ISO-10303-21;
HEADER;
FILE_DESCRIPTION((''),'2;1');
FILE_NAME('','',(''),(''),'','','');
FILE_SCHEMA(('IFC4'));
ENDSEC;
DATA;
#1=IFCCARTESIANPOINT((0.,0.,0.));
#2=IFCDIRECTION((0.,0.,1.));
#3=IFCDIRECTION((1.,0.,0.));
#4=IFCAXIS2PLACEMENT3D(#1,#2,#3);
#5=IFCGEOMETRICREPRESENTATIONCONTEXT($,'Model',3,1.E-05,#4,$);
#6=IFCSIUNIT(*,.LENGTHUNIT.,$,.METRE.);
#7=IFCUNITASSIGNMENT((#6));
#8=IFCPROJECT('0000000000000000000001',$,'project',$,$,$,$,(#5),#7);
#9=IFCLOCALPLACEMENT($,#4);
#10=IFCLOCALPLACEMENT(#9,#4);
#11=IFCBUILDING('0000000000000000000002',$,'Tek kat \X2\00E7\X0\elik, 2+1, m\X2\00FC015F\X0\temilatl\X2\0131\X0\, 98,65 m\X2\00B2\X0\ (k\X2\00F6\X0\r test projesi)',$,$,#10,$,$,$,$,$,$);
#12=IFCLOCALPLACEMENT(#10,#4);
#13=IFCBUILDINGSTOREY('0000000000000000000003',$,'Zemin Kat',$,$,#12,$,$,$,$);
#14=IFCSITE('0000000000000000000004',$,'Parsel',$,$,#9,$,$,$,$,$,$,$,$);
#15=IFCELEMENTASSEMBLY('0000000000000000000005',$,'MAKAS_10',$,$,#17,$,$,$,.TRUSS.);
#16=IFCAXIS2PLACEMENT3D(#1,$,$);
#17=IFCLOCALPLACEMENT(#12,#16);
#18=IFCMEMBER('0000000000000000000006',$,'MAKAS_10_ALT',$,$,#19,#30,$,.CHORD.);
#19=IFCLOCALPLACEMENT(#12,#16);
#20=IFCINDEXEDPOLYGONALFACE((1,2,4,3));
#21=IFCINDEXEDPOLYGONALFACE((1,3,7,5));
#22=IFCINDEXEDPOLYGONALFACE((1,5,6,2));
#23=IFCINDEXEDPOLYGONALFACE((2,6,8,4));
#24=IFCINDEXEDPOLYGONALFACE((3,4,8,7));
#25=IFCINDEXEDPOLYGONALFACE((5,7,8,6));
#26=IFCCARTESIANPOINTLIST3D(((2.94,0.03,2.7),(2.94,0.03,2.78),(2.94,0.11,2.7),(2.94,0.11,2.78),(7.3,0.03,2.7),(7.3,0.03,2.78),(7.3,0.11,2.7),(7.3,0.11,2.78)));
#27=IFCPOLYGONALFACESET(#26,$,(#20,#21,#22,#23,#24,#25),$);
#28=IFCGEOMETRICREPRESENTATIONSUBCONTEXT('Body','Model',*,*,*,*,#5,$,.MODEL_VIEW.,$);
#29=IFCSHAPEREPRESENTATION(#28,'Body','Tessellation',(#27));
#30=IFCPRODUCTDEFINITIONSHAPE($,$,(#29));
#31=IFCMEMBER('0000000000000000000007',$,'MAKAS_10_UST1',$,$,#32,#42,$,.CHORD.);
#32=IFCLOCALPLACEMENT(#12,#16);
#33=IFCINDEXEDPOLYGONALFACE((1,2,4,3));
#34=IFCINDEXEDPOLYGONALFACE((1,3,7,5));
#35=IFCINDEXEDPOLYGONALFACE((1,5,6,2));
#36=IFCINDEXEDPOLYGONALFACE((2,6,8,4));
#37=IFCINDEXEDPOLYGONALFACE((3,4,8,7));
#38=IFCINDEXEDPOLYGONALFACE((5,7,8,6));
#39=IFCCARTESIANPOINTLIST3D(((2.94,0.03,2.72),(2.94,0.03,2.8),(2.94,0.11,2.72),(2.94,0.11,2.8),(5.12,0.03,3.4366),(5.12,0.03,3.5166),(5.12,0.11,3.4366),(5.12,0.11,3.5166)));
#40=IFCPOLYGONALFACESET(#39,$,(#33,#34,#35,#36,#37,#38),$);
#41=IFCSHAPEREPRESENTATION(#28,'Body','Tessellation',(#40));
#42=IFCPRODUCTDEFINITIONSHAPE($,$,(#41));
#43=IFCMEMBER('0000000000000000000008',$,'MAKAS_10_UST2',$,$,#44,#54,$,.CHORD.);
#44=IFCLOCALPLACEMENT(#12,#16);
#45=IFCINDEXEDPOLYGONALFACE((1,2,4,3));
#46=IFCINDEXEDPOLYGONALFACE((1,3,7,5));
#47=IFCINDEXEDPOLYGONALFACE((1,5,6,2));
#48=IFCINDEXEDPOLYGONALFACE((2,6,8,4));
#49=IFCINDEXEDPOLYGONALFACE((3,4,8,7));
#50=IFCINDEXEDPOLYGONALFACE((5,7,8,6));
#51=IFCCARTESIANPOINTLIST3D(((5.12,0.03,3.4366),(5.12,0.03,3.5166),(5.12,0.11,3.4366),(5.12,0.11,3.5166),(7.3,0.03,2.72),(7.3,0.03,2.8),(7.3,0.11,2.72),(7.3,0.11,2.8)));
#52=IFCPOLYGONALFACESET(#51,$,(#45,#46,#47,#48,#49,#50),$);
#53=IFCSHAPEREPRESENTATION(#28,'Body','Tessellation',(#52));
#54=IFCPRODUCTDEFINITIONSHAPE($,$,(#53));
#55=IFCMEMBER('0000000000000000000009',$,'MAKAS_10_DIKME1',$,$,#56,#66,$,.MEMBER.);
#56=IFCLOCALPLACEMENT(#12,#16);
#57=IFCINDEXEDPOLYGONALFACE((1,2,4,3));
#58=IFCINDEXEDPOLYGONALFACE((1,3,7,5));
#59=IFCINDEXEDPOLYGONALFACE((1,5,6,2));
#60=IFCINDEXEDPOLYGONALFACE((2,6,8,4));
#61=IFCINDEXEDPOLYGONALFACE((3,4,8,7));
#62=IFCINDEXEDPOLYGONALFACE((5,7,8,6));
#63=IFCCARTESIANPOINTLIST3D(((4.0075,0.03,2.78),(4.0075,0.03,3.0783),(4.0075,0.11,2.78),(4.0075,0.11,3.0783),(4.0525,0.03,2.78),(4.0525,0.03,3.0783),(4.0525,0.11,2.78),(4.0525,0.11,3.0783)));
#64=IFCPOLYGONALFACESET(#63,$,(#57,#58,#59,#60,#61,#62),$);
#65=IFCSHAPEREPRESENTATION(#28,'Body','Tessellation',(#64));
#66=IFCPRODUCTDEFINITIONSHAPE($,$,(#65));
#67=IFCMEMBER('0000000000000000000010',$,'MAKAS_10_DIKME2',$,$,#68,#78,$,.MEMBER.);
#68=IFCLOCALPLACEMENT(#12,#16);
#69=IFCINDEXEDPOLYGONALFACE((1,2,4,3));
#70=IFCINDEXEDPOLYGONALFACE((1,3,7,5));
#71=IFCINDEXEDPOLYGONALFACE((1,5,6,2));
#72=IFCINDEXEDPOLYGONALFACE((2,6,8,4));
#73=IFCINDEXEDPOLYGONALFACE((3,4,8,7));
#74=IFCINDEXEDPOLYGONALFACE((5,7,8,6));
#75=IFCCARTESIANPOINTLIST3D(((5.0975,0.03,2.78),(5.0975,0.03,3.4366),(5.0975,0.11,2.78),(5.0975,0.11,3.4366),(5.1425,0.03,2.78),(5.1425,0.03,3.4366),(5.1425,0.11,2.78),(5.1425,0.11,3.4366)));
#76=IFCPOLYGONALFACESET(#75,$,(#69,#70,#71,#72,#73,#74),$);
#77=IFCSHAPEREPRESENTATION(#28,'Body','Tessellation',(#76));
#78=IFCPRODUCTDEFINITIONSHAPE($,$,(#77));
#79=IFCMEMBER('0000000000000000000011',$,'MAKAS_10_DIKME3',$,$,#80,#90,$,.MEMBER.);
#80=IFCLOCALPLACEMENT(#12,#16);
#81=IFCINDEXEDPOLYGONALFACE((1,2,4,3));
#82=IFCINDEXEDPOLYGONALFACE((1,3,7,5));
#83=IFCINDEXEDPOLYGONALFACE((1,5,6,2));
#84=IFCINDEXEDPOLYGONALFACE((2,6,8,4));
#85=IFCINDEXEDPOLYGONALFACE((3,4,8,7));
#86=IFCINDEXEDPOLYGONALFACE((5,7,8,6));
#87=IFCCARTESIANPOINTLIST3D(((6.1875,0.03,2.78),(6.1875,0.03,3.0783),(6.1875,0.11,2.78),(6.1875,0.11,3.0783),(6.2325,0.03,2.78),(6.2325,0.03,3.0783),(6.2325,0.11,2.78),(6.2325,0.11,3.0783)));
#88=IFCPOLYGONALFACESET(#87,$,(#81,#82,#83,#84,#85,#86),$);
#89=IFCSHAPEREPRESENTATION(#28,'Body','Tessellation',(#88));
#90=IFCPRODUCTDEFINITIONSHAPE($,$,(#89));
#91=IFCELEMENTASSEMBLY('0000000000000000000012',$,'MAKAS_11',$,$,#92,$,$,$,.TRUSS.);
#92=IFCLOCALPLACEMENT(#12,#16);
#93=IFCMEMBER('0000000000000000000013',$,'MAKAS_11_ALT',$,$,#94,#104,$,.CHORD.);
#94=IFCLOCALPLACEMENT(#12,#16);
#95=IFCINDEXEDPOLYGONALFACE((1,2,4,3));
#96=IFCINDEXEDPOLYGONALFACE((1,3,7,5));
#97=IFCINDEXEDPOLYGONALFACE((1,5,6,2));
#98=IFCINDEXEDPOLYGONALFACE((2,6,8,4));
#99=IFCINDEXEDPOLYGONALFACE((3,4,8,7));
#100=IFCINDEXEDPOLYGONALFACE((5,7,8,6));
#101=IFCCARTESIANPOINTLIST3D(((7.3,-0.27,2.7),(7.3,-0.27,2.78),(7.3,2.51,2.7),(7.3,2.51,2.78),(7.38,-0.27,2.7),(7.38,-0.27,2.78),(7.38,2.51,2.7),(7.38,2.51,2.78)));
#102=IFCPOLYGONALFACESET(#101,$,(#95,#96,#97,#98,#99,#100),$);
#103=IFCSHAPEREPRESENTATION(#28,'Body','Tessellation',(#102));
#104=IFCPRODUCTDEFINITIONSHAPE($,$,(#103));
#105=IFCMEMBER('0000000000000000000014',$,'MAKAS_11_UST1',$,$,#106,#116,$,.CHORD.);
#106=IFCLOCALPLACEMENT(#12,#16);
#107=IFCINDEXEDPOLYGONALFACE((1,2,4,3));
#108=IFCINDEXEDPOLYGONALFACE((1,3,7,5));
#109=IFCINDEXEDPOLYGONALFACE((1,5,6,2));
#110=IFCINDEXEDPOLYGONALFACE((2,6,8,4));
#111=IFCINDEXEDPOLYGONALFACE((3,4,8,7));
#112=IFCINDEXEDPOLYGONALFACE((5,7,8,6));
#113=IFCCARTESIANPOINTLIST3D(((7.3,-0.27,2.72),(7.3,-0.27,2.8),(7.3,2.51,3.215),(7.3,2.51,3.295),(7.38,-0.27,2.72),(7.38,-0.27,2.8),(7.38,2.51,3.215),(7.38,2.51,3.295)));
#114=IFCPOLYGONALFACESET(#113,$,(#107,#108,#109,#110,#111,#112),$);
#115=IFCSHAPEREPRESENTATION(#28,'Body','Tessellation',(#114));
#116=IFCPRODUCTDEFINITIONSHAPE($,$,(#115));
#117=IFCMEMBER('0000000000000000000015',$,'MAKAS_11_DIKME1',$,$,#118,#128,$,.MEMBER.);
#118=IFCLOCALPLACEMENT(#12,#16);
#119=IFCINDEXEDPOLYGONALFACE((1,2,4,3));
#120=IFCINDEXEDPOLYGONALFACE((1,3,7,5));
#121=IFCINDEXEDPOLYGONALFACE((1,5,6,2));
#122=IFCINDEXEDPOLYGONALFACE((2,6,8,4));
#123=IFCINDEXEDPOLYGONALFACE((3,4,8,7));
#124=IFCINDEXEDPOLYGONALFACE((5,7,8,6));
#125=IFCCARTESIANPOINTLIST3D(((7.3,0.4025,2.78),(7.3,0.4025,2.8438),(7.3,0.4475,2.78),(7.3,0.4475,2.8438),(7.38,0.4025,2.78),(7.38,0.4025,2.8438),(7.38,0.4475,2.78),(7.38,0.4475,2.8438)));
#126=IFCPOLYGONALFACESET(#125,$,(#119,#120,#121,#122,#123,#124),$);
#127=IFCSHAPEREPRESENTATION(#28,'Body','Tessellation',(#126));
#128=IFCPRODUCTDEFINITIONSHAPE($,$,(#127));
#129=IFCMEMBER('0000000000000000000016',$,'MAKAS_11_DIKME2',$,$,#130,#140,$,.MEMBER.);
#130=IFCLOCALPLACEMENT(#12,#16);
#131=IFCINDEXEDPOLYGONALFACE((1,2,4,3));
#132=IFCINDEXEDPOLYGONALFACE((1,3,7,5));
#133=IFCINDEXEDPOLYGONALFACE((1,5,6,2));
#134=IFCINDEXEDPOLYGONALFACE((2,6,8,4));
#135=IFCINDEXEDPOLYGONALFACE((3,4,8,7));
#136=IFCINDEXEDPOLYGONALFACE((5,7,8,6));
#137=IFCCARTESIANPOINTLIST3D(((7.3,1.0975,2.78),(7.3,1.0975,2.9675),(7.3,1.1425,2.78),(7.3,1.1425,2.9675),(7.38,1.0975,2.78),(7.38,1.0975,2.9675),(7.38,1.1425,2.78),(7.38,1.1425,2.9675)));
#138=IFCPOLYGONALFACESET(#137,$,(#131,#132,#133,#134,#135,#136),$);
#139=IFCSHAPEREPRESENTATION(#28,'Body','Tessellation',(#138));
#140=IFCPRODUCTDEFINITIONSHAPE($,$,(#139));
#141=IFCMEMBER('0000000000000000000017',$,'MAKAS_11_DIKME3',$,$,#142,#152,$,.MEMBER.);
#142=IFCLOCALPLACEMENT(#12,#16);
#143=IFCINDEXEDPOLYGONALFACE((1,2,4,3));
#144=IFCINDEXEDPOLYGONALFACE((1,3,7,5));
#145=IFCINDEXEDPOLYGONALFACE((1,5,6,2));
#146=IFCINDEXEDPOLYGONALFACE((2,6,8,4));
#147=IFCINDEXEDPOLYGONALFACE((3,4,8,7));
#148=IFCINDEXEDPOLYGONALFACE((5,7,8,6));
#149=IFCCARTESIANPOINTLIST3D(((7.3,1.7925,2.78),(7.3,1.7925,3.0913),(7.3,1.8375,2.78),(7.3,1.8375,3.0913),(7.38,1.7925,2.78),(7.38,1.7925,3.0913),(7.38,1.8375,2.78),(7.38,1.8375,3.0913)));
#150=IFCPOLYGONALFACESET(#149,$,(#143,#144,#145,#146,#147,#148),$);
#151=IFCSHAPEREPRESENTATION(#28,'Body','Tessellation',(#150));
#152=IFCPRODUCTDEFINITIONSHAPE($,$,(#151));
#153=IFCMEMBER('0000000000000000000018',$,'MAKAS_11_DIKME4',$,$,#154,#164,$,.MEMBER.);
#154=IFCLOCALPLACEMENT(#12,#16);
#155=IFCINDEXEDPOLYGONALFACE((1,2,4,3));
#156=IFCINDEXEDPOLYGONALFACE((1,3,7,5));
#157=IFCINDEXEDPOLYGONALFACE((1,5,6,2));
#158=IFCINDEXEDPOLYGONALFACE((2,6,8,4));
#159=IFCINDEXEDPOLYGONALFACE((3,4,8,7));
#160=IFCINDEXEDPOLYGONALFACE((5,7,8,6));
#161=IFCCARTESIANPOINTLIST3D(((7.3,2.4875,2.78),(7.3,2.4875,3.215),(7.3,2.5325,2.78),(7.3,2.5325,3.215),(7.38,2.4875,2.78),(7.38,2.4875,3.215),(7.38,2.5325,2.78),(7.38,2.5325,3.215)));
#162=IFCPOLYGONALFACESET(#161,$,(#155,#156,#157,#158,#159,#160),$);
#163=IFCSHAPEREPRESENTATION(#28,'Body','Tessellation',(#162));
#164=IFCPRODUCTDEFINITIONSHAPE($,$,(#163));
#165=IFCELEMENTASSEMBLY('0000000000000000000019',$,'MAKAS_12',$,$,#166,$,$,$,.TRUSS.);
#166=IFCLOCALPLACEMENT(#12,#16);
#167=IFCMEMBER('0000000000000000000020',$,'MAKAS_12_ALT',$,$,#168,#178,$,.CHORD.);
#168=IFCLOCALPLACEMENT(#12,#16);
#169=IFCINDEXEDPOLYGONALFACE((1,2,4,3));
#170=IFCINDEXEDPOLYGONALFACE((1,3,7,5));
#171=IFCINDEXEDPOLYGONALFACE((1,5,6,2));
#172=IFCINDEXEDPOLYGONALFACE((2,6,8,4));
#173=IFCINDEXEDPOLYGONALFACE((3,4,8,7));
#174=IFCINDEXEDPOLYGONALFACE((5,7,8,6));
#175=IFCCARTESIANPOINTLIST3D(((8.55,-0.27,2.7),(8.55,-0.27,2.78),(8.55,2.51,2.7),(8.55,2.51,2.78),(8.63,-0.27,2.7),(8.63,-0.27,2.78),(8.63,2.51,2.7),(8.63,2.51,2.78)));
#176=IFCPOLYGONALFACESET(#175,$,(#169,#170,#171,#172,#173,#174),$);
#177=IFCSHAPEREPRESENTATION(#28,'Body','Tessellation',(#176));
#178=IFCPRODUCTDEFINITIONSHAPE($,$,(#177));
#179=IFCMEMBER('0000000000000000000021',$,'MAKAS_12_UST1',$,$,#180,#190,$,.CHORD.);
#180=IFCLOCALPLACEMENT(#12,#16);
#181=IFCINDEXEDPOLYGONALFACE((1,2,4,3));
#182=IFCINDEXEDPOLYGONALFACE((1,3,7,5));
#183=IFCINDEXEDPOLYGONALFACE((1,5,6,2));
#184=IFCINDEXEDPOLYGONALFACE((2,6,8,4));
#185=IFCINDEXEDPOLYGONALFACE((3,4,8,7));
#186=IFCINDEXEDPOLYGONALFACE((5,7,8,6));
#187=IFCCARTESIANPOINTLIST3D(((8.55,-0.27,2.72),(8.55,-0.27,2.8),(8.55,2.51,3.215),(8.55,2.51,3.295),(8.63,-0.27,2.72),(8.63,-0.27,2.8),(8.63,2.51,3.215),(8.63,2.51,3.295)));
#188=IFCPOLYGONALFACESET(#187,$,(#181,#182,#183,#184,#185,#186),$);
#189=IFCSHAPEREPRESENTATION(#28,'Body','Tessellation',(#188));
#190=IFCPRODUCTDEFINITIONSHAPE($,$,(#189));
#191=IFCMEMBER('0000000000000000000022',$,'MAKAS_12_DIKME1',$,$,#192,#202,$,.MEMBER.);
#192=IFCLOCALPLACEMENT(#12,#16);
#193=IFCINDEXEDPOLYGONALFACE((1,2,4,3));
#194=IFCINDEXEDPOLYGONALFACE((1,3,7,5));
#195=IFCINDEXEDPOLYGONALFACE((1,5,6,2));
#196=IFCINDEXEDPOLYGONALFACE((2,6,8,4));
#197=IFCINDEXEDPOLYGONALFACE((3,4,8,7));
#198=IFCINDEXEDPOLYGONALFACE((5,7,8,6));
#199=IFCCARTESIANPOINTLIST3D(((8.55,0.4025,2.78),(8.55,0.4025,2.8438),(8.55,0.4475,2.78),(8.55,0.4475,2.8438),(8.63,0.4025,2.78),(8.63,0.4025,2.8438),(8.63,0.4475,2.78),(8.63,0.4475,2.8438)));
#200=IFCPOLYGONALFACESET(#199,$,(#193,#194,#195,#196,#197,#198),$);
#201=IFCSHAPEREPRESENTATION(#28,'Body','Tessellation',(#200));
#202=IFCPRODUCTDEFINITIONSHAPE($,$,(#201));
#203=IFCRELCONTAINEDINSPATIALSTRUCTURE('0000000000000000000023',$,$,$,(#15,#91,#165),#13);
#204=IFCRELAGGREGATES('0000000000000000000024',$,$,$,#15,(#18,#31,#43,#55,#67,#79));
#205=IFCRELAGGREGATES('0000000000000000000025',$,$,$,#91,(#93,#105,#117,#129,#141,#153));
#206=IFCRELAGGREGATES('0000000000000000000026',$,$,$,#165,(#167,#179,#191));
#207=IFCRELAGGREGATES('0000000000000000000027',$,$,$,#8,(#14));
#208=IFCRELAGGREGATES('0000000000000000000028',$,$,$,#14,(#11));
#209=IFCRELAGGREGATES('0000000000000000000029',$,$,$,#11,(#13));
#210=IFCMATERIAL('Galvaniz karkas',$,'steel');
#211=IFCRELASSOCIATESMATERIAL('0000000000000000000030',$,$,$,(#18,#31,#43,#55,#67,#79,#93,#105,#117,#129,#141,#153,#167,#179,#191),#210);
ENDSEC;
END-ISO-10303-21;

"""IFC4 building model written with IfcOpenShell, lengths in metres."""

from ifc_helpers import new_model, si_unit, frame, origin_with_axes, place, context, subcontext, project, spatial, line, indexed_curve, outline, extrude, material, element, aggregate, save


model = new_model("IFC4")

# Units and contexts
model_context = context("Model", 3, precision=1e-05, world=origin_with_axes())
body_context = subcontext(model_context, "Body", "Model", "MODEL_VIEW")
ifc_project = project(units=[si_unit("LENGTHUNIT", "METRE")], contexts=[model_context])

# Site, building, storey
site_placement = place(None, origin_with_axes())
site = spatial("IfcSite", under=ifc_project, at=site_placement, Name="Parsel")
building_placement = place(site_placement, origin_with_axes())
building = spatial("IfcBuilding", under=site, at=building_placement, Name="Tek kat çelik, 2+1, müştemilatlı, 98,65 m² (kör test projesi)")
storey_placement = place(building_placement, origin_with_axes())
storey = spatial("IfcBuildingStorey", under=building, at=storey_placement, Name="Zemin Kat")

# Element assemblies, members
assembly_1_placement = place(storey_placement, origin_with_axes())
assembly_1 = element("IfcElementAssembly", 1, at=assembly_1_placement, inside=storey, Name="MAKAS_10", PredefinedType="TRUSS")
ifc_material = material(Name="Galvaniz karkas", Category="steel")
member_1_placement = place(assembly_1_placement, origin_with_axes())
member_1 = element("IfcMember", 2, at=member_1_placement, material=ifc_material, Name="MAKAS_10_ALT", PredefinedType="CHORD", context=body_context, shape_type="SweptSolid", body=[
    extrude(outline(indexed_curve([(2.94, 2.7), (7.3, 2.7), (7.3, 2.78), (2.94, 2.78)], segments=[line(1, 2, 3, 4, 1)])), frame((0.0, 0.11, 0.0), z_axis=(0.0, -1.0, 0.0), x_axis=(1.0, 0.0, 0.0)), (0.0, 0.0, 1.0), 0.08),
])
member_2_placement = place(assembly_1_placement, origin_with_axes())
member_2 = element("IfcMember", 3, at=member_2_placement, material=ifc_material, Name="MAKAS_10_UST1", PredefinedType="CHORD", context=body_context, shape_type="SweptSolid", body=[
    extrude(outline(indexed_curve([(2.94, 2.72), (5.12, 3.4366), (5.12, 3.5166), (2.94, 2.8)], segments=[line(1, 2, 3, 4, 1)])), frame((0.0, 0.11, 0.0), z_axis=(0.0, -1.0, 0.0), x_axis=(1.0, 0.0, 0.0)), (0.0, 0.0, 1.0), 0.08),
])
member_3_placement = place(assembly_1_placement, origin_with_axes())
member_3 = element("IfcMember", 4, at=member_3_placement, material=ifc_material, Name="MAKAS_10_UST2", PredefinedType="CHORD", context=body_context, shape_type="SweptSolid", body=[
    extrude(outline(indexed_curve([(5.12, 3.4366), (7.3, 2.72), (7.3, 2.8), (5.12, 3.5166)], segments=[line(1, 2, 3, 4, 1)])), frame((0.0, 0.11, 0.0), z_axis=(0.0, -1.0, 0.0), x_axis=(1.0, 0.0, 0.0)), (0.0, 0.0, 1.0), 0.08),
])
member_4_placement = place(assembly_1_placement, origin_with_axes())
member_4 = element("IfcMember", 5, at=member_4_placement, material=ifc_material, Name="MAKAS_10_DIKME1", PredefinedType="MEMBER", context=body_context, shape_type="SweptSolid", body=[
    extrude(outline(indexed_curve([(4.0075, 2.78), (4.0525, 2.78), (4.0525, 3.0783), (4.0075, 3.0783)], segments=[line(1, 2, 3, 4, 1)])), frame((0.0, 0.11, 0.0), z_axis=(0.0, -1.0, 0.0), x_axis=(1.0, 0.0, 0.0)), (0.0, 0.0, 1.0), 0.08),
])
member_5_placement = place(assembly_1_placement, origin_with_axes())
member_5 = element("IfcMember", 6, at=member_5_placement, material=ifc_material, Name="MAKAS_10_DIKME2", PredefinedType="MEMBER", context=body_context, shape_type="SweptSolid", body=[
    extrude(outline(indexed_curve([(5.0975, 2.78), (5.1425, 2.78), (5.1425, 3.4366), (5.0975, 3.4366)], segments=[line(1, 2, 3, 4, 1)])), frame((0.0, 0.11, 0.0), z_axis=(0.0, -1.0, 0.0), x_axis=(1.0, 0.0, 0.0)), (0.0, 0.0, 1.0), 0.08),
])
member_6_placement = place(assembly_1_placement, origin_with_axes())
member_6 = element("IfcMember", 7, at=member_6_placement, material=ifc_material, Name="MAKAS_10_DIKME3", PredefinedType="MEMBER", context=body_context, shape_type="SweptSolid", body=[
    extrude(outline(indexed_curve([(6.1875, 2.78), (6.2325, 2.78), (6.2325, 3.0783), (6.1875, 3.0783)], segments=[line(1, 2, 3, 4, 1)])), frame((0.0, 0.11, 0.0), z_axis=(0.0, -1.0, 0.0), x_axis=(1.0, 0.0, 0.0)), (0.0, 0.0, 1.0), 0.08),
])
aggregate(assembly_1, [member_1, member_2, member_3, member_4, member_5, member_6])
assembly_2_placement = place(storey_placement, origin_with_axes())
assembly_2 = element("IfcElementAssembly", 8, at=assembly_2_placement, inside=storey, Name="MAKAS_11", PredefinedType="TRUSS")
member_7_placement = place(assembly_2_placement, origin_with_axes())
member_7 = element("IfcMember", 9, at=member_7_placement, material=ifc_material, Name="MAKAS_11_ALT", PredefinedType="CHORD", context=body_context, shape_type="SweptSolid", body=[
    extrude(outline(indexed_curve([(-0.27, 2.7), (2.51, 2.7), (2.51, 2.78), (-0.27, 2.78)], segments=[line(1, 2, 3, 4, 1)])), frame((7.3, 0.0, 0.0), z_axis=(1.0, 0.0, 0.0), x_axis=(0.0, 1.0, 0.0)), (0.0, 0.0, 1.0), 0.08),
])
member_8_placement = place(assembly_2_placement, origin_with_axes())
member_8 = element("IfcMember", 10, at=member_8_placement, material=ifc_material, Name="MAKAS_11_UST1", PredefinedType="CHORD", context=body_context, shape_type="SweptSolid", body=[
    extrude(outline(indexed_curve([(-0.27, 2.72), (2.51, 3.215), (2.51, 3.295), (-0.27, 2.8)], segments=[line(1, 2, 3, 4, 1)])), frame((7.3, 0.0, 0.0), z_axis=(1.0, 0.0, 0.0), x_axis=(0.0, 1.0, 0.0)), (0.0, 0.0, 1.0), 0.08),
])
member_9_placement = place(assembly_2_placement, origin_with_axes())
member_9 = element("IfcMember", 11, at=member_9_placement, material=ifc_material, Name="MAKAS_11_DIKME1", PredefinedType="MEMBER", context=body_context, shape_type="SweptSolid", body=[
    extrude(outline(indexed_curve([(0.4025, 2.78), (0.4475, 2.78), (0.4475, 2.8438), (0.4025, 2.8438)], segments=[line(1, 2, 3, 4, 1)])), frame((7.3, 0.0, 0.0), z_axis=(1.0, 0.0, 0.0), x_axis=(0.0, 1.0, 0.0)), (0.0, 0.0, 1.0), 0.08),
])
member_10_placement = place(assembly_2_placement, origin_with_axes())
member_10 = element("IfcMember", 12, at=member_10_placement, material=ifc_material, Name="MAKAS_11_DIKME2", PredefinedType="MEMBER", context=body_context, shape_type="SweptSolid", body=[
    extrude(outline(indexed_curve([(1.0975, 2.78), (1.1425, 2.78), (1.1425, 2.9675), (1.0975, 2.9675)], segments=[line(1, 2, 3, 4, 1)])), frame((7.3, 0.0, 0.0), z_axis=(1.0, 0.0, 0.0), x_axis=(0.0, 1.0, 0.0)), (0.0, 0.0, 1.0), 0.08),
])
member_11_placement = place(assembly_2_placement, origin_with_axes())
member_11 = element("IfcMember", 13, at=member_11_placement, material=ifc_material, Name="MAKAS_11_DIKME3", PredefinedType="MEMBER", context=body_context, shape_type="SweptSolid", body=[
    extrude(outline(indexed_curve([(1.7925, 2.78), (1.8375, 2.78), (1.8375, 3.0913), (1.7925, 3.0913)], segments=[line(1, 2, 3, 4, 1)])), frame((7.3, 0.0, 0.0), z_axis=(1.0, 0.0, 0.0), x_axis=(0.0, 1.0, 0.0)), (0.0, 0.0, 1.0), 0.08),
])
member_12_placement = place(assembly_2_placement, origin_with_axes())
member_12 = element("IfcMember", 14, at=member_12_placement, material=ifc_material, Name="MAKAS_11_DIKME4", PredefinedType="MEMBER", context=body_context, shape_type="SweptSolid", body=[
    extrude(outline(indexed_curve([(2.4875, 2.78), (2.5325, 2.78), (2.5325, 3.215), (2.4875, 3.215)], segments=[line(1, 2, 3, 4, 1)])), frame((7.3, 0.0, 0.0), z_axis=(1.0, 0.0, 0.0), x_axis=(0.0, 1.0, 0.0)), (0.0, 0.0, 1.0), 0.08),
])
aggregate(assembly_2, [member_7, member_8, member_9, member_10, member_11, member_12])
assembly_3_placement = place(storey_placement, origin_with_axes())
assembly_3 = element("IfcElementAssembly", 15, at=assembly_3_placement, inside=storey, Name="MAKAS_12", PredefinedType="TRUSS")
member_13_placement = place(assembly_3_placement, origin_with_axes())
member_13 = element("IfcMember", 16, at=member_13_placement, material=ifc_material, Name="MAKAS_12_ALT", PredefinedType="CHORD", context=body_context, shape_type="SweptSolid", body=[
    extrude(outline(indexed_curve([(-0.27, 2.7), (2.51, 2.7), (2.51, 2.78), (-0.27, 2.78)], segments=[line(1, 2, 3, 4, 1)])), frame((8.55, 0.0, 0.0), z_axis=(1.0, 0.0, 0.0), x_axis=(0.0, 1.0, 0.0)), (0.0, 0.0, 1.0), 0.08),
])
member_14_placement = place(assembly_3_placement, origin_with_axes())
member_14 = element("IfcMember", 17, at=member_14_placement, material=ifc_material, Name="MAKAS_12_UST1", PredefinedType="CHORD", context=body_context, shape_type="SweptSolid", body=[
    extrude(outline(indexed_curve([(-0.27, 2.72), (2.51, 3.215), (2.51, 3.295), (-0.27, 2.8)], segments=[line(1, 2, 3, 4, 1)])), frame((8.55, 0.0, 0.0), z_axis=(1.0, 0.0, 0.0), x_axis=(0.0, 1.0, 0.0)), (0.0, 0.0, 1.0), 0.08),
])
member_15_placement = place(assembly_3_placement, origin_with_axes())
member_15 = element("IfcMember", 18, at=member_15_placement, material=ifc_material, Name="MAKAS_12_DIKME1", PredefinedType="MEMBER", context=body_context, shape_type="SweptSolid", body=[
    extrude(outline(indexed_curve([(0.4025, 2.78), (0.4475, 2.78), (0.4475, 2.8438), (0.4025, 2.8438)], segments=[line(1, 2, 3, 4, 1)])), frame((8.55, 0.0, 0.0), z_axis=(1.0, 0.0, 0.0), x_axis=(0.0, 1.0, 0.0)), (0.0, 0.0, 1.0), 0.08),
])
aggregate(assembly_3, [member_13, member_14, member_15])

save(model, "model.ifc")
